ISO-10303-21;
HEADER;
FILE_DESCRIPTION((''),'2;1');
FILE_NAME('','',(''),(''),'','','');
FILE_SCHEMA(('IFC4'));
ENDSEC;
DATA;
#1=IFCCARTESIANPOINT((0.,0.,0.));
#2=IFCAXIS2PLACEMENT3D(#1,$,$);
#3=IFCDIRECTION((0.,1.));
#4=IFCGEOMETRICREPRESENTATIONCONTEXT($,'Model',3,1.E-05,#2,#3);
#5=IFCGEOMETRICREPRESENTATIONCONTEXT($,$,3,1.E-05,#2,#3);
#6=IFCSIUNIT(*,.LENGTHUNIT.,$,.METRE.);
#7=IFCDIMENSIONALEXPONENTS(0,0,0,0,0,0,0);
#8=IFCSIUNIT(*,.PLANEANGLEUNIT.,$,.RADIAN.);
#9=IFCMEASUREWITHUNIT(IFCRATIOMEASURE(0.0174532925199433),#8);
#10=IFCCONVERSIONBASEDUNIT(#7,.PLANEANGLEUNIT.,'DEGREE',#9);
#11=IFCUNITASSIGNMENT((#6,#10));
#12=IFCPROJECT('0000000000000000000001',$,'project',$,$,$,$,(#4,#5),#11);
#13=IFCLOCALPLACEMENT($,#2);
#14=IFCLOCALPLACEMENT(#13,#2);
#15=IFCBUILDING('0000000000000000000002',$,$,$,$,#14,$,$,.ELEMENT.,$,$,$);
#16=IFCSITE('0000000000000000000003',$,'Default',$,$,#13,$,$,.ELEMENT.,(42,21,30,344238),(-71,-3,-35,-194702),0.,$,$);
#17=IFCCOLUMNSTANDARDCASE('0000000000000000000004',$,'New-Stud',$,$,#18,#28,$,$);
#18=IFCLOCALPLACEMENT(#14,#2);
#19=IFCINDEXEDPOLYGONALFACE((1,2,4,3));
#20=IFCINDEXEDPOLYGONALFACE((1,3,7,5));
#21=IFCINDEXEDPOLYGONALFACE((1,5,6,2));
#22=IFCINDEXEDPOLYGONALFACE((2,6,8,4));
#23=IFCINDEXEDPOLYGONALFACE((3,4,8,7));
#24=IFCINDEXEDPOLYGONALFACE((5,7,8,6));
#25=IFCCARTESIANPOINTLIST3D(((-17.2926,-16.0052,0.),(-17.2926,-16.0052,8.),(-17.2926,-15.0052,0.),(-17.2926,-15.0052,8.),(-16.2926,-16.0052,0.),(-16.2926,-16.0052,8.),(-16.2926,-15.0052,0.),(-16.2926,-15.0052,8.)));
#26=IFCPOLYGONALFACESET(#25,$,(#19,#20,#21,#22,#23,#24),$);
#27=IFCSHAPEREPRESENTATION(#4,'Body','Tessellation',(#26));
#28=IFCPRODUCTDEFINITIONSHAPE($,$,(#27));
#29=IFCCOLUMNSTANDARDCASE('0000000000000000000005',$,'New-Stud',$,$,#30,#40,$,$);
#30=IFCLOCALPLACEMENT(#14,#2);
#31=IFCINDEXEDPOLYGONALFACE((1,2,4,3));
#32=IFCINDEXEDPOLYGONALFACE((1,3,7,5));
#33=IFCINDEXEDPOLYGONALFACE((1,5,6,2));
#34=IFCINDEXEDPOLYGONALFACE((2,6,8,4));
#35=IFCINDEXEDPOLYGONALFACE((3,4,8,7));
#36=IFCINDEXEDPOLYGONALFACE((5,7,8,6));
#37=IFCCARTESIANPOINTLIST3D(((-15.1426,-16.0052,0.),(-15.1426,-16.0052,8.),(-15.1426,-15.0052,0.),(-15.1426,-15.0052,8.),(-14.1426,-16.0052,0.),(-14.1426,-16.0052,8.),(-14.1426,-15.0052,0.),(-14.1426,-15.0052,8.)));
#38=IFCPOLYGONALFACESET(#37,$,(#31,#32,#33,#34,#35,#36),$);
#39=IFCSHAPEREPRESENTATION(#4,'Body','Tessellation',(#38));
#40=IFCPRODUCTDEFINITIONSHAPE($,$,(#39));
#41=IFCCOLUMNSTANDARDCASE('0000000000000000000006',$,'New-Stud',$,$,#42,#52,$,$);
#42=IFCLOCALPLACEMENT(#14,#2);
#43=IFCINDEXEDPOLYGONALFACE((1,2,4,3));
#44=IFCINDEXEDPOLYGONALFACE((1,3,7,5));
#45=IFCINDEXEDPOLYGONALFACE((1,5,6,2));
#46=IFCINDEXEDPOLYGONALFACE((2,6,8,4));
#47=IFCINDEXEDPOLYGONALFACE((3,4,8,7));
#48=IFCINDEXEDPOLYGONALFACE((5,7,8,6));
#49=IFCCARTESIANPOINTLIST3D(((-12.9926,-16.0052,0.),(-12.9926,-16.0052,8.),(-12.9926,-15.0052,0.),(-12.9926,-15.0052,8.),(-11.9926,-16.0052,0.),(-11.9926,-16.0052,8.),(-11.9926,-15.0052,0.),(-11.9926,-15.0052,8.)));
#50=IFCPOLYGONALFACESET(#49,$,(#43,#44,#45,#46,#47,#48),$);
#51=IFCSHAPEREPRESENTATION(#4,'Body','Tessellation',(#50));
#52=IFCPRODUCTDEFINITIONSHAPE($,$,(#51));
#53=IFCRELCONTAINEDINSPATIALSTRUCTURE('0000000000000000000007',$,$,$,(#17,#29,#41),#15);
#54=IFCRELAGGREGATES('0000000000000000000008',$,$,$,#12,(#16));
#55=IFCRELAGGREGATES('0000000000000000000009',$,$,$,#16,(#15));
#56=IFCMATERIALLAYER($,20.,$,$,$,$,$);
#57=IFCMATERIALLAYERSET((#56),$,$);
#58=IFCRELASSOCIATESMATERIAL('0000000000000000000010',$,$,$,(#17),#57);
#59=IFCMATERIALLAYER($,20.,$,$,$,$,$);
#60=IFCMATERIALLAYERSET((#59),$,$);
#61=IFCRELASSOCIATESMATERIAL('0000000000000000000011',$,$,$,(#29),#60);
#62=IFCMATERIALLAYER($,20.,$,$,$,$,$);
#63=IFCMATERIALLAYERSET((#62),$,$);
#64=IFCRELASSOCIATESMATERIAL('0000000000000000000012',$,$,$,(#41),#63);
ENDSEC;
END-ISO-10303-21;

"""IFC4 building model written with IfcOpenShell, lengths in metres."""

from ifc_helpers import new_model, entity, si_unit, converted_unit, direction, frame, origin, origin_with_axes, origin_2d, place, context, project, spatial, rectangle, extrude, layer, layer_set, layer_usage, element, save


model = new_model("IFC4")

# Units and contexts
model_context = context("Model", 3, precision=1e-05, world=origin(), true_north=direction((0.0, 1.0)))
context_of_model = context(None, 3, precision=1e-05, world=origin(), true_north=direction((0.0, 1.0)))
ifc_project = project(units=[si_unit("LENGTHUNIT", "METRE"), converted_unit("PLANEANGLEUNIT", "DEGREE", entity("IfcRatioMeasure", 0.0174532925199433), si_unit("PLANEANGLEUNIT", "RADIAN"), dimensions=[0, 0, 0, 0, 0, 0, 0])], contexts=[model_context, context_of_model])

# Site, building
site_placement = place(None, origin())
site = spatial("IfcSite", under=ifc_project, at=site_placement, Name="Default", CompositionType="ELEMENT", RefLatitude=(42, 21, 30, 344238), RefLongitude=(-71, -3, -35, -194702), RefElevation=0.0)
building_placement = place(site_placement, origin())
building = spatial("IfcBuilding", under=site, at=building_placement, CompositionType="ELEMENT")

# Columns
ifc_layer_1 = layer(None, 20.0)
ifc_layer_set_1 = layer_set([ifc_layer_1])
ifc_layer_usage_1 = layer_usage(ifc_layer_set_1, "AXIS2", "POSITIVE", 150.0)
placement_1 = place(building_placement, origin())
placement_2 = place(placement_1, frame((-16.7926, -15.5052, 0.0), z_axis=(0.0, 0.0, 1.0), x_axis=(0.0, 1.0, 0.0)))
column_1_placement = place(placement_2, origin_with_axes())
element("IfcColumnStandardCase", 1, at=column_1_placement, inside=building, material=ifc_layer_usage_1, Name="New-Stud", context=model_context, shape_type="SweptSolid", body=[
    extrude(rectangle(XDim=1.0, YDim=1.0, at=origin_2d()), origin(), (0.0, 0.0, 1.0), 8.0),
])
ifc_layer_2 = layer(None, 20.0)
ifc_layer_set_2 = layer_set([ifc_layer_2])
ifc_layer_usage_2 = layer_usage(ifc_layer_set_2, "AXIS2", "POSITIVE", 150.0)
placement_3 = place(placement_1, frame((-14.6426, -15.5052, 0.0), z_axis=(0.0, 0.0, 1.0), x_axis=(0.0, 1.0, 0.0)))
column_2_placement = place(placement_3, origin_with_axes())
element("IfcColumnStandardCase", 2, at=column_2_placement, inside=building, material=ifc_layer_usage_2, Name="New-Stud", context=model_context, shape_type="SweptSolid", body=[
    extrude(rectangle(XDim=1.0, YDim=1.0, at=origin_2d()), origin(), (0.0, 0.0, 1.0), 8.0),
])
ifc_layer_3 = layer(None, 20.0)
ifc_layer_set_3 = layer_set([ifc_layer_3])
ifc_layer_usage_3 = layer_usage(ifc_layer_set_3, "AXIS2", "POSITIVE", 150.0)
placement_4 = place(placement_1, frame((-12.4926, -15.5052, 0.0), z_axis=(0.0, 0.0, 1.0), x_axis=(0.0, 1.0, 0.0)))
column_3_placement = place(placement_4, origin_with_axes())
element("IfcColumnStandardCase", 3, at=column_3_placement, inside=building, material=ifc_layer_usage_3, Name="New-Stud", context=model_context, shape_type="SweptSolid", body=[
    extrude(rectangle(XDim=1.0, YDim=1.0, at=origin_2d()), origin(), (0.0, 0.0, 1.0), 8.0),
])

save(model, "model.ifc")
